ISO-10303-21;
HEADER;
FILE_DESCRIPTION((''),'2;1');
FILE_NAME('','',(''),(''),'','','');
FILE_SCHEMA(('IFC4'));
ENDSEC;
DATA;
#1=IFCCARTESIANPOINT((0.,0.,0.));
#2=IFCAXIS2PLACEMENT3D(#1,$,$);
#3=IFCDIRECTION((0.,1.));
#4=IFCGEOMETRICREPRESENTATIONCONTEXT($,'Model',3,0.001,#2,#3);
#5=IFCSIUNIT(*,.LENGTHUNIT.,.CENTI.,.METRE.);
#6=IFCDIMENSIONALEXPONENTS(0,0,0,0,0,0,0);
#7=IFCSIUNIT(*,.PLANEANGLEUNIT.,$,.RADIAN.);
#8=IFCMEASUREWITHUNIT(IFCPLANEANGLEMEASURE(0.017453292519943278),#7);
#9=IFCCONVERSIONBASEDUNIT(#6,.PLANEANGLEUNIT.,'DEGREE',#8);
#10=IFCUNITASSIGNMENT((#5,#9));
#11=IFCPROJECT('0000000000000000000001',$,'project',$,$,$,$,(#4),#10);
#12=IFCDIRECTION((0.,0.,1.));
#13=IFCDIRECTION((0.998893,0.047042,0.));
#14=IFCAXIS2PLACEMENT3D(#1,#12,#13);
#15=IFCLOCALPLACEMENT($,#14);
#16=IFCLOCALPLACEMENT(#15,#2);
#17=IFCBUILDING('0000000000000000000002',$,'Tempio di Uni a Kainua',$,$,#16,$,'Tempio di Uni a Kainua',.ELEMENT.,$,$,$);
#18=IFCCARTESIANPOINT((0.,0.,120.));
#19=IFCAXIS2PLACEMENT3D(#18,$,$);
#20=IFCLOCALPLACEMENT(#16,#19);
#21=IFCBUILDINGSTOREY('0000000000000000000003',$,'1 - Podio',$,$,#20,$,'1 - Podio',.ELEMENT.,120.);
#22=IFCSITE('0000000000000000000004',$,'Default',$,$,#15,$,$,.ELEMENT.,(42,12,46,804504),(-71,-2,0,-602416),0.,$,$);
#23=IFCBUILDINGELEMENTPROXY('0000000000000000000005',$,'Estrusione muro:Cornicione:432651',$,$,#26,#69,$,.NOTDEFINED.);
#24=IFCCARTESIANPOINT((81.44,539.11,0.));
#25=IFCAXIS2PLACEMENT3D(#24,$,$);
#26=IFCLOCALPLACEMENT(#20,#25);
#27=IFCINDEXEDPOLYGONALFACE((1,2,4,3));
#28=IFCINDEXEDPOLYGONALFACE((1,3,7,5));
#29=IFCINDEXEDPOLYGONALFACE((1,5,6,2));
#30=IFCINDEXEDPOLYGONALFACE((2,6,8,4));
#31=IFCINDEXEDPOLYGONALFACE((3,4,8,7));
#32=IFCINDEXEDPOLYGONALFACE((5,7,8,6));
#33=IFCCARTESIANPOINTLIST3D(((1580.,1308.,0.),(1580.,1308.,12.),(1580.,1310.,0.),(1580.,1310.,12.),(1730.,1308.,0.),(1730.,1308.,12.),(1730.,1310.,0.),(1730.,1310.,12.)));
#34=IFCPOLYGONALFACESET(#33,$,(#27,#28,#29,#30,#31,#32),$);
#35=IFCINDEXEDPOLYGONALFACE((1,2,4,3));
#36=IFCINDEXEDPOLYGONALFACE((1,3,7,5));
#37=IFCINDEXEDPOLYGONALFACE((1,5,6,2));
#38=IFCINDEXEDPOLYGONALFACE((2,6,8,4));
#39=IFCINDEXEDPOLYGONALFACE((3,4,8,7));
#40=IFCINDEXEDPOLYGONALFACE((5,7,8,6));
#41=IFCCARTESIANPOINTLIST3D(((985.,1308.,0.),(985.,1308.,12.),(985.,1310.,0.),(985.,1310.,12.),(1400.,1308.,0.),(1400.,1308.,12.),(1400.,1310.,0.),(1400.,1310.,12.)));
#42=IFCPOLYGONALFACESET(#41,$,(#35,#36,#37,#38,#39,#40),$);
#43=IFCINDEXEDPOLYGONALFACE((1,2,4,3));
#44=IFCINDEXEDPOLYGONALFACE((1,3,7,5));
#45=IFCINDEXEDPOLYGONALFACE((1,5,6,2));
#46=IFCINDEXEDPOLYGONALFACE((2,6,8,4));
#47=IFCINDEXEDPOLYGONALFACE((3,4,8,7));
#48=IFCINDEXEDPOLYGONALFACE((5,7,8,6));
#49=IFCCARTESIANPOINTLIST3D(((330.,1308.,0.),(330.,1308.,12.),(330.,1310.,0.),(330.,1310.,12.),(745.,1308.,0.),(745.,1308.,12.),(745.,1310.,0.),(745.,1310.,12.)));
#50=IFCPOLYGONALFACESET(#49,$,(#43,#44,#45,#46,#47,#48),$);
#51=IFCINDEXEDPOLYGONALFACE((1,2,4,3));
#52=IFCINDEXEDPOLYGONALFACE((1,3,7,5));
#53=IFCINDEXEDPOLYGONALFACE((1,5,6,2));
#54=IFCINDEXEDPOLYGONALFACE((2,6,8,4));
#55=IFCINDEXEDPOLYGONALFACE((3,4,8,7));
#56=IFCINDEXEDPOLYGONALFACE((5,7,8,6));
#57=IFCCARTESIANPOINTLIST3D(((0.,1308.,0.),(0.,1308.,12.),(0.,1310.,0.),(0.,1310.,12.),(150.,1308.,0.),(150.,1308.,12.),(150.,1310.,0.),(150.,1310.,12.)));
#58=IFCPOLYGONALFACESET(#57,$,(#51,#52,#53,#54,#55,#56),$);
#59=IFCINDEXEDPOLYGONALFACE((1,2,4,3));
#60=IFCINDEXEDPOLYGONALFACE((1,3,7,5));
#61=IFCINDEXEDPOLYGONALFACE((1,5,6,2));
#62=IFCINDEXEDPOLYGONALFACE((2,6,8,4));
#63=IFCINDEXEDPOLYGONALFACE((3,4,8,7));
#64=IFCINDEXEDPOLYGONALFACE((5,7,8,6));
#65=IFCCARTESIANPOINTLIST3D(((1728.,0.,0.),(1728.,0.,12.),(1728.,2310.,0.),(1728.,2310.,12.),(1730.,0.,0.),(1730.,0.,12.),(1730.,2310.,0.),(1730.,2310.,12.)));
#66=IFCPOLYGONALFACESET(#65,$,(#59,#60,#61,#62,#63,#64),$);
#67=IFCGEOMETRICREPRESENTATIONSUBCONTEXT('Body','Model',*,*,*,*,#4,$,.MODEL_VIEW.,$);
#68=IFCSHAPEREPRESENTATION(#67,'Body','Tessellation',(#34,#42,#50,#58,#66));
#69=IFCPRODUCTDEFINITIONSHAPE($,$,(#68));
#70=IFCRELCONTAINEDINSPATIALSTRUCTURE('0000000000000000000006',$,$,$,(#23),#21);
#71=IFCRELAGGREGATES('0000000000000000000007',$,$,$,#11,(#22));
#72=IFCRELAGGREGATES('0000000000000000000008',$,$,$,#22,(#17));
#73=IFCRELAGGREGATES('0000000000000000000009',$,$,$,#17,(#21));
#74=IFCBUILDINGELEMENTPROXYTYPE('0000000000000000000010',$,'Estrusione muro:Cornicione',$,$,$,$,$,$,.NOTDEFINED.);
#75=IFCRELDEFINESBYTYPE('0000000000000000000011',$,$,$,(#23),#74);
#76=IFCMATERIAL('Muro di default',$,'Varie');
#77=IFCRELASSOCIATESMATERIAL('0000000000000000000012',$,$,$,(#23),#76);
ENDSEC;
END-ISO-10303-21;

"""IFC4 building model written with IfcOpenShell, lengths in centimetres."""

from ifc_helpers import new_model, entity, si_unit, converted_unit, direction, frame, frame_2d, origin, origin_2d_with_axis, place, context, subcontext, project, spatial, rectangle, extrude, material, type_object, element, save


model = new_model("IFC4")

# Units and contexts
model_context = context("Model", 3, precision=0.001, world=origin(), true_north=direction((0.0, 1.0)))
body_context = subcontext(model_context, "Body", "Model", "MODEL_VIEW")
ifc_project = project(units=[si_unit("LENGTHUNIT", "METRE", prefix="CENTI"), converted_unit("PLANEANGLEUNIT", "DEGREE", entity("IfcPlaneAngleMeasure", 0.017453292519943278), si_unit("PLANEANGLEUNIT", "RADIAN"), dimensions=[0, 0, 0, 0, 0, 0, 0])], contexts=[model_context])

# Site, building, storey
site_placement = place(None, frame((0.0, 0.0, 0.0), z_axis=(0.0, 0.0, 1.0), x_axis=(0.998893, 0.047042, 0.0)))
site = spatial("IfcSite", under=ifc_project, at=site_placement, Name="Default", CompositionType="ELEMENT", RefLatitude=(42, 12, 46, 804504), RefLongitude=(-71, -2, 0, -602416), RefElevation=0.0)
building_placement = place(site_placement, origin())
building = spatial("IfcBuilding", under=site, at=building_placement, Name="Tempio di Uni a Kainua", LongName="Tempio di Uni a Kainua", CompositionType="ELEMENT")
storey_placement = place(building_placement, frame((0.0, 0.0, 120.0)))
storey = spatial("IfcBuildingStorey", under=building, at=storey_placement, Name="1 - Podio", LongName="1 - Podio", CompositionType="ELEMENT", Elevation=120.0)

# Building element proxy
ifc_material_1 = material(Name="Muro di default", Category="Varie")
building_element_proxy_type = type_object("IfcBuildingElementProxyType", Name="Estrusione muro:Cornicione", PredefinedType="NOTDEFINED")
proxy_1_placement = place(storey_placement, frame((81.44, 539.11, 0.0)))
element("IfcBuildingElementProxy", 1, at=proxy_1_placement, inside=storey, type_object=building_element_proxy_type, material=ifc_material_1, Name="Estrusione muro:Cornicione:432651", PredefinedType="NOTDEFINED", context=body_context, shape_type="SweptSolid", body=[
    extrude(rectangle(XDim=150.0, YDim=2.0, at=origin_2d_with_axis()), frame((1655.0, 1309.0, 0.0)), (0.0, 0.0, 1.0), 12.0),
    extrude(rectangle(XDim=415.0, YDim=2.0, at=frame_2d((0.0, 0.0), x_axis=(1.0, 0.0))), frame((1192.5, 1309.0, 0.0)), (0.0, 0.0, 1.0), 12.0),
    extrude(rectangle(XDim=415.0, YDim=2.0, at=frame_2d((0.0, 0.0), x_axis=(1.0, 0.0))), frame((537.5, 1309.0, 0.0)), (0.0, 0.0, 1.0), 12.0),
    extrude(rectangle(XDim=150.0, YDim=2.0, at=origin_2d_with_axis()), frame((75.0, 1309.0, 0.0)), (0.0, 0.0, 1.0), 12.0),
    extrude(rectangle(XDim=2310.0, YDim=2.0, at=frame_2d((0.0, 0.0), x_axis=(1.0, 0.0))), frame((1729.0, 1155.0, 0.0), z_axis=(0.0, 0.0, 1.0), x_axis=(0.0, -1.0, 0.0)), (0.0, 0.0, 1.0), 12.0),
])

save(model, "model.ifc")
